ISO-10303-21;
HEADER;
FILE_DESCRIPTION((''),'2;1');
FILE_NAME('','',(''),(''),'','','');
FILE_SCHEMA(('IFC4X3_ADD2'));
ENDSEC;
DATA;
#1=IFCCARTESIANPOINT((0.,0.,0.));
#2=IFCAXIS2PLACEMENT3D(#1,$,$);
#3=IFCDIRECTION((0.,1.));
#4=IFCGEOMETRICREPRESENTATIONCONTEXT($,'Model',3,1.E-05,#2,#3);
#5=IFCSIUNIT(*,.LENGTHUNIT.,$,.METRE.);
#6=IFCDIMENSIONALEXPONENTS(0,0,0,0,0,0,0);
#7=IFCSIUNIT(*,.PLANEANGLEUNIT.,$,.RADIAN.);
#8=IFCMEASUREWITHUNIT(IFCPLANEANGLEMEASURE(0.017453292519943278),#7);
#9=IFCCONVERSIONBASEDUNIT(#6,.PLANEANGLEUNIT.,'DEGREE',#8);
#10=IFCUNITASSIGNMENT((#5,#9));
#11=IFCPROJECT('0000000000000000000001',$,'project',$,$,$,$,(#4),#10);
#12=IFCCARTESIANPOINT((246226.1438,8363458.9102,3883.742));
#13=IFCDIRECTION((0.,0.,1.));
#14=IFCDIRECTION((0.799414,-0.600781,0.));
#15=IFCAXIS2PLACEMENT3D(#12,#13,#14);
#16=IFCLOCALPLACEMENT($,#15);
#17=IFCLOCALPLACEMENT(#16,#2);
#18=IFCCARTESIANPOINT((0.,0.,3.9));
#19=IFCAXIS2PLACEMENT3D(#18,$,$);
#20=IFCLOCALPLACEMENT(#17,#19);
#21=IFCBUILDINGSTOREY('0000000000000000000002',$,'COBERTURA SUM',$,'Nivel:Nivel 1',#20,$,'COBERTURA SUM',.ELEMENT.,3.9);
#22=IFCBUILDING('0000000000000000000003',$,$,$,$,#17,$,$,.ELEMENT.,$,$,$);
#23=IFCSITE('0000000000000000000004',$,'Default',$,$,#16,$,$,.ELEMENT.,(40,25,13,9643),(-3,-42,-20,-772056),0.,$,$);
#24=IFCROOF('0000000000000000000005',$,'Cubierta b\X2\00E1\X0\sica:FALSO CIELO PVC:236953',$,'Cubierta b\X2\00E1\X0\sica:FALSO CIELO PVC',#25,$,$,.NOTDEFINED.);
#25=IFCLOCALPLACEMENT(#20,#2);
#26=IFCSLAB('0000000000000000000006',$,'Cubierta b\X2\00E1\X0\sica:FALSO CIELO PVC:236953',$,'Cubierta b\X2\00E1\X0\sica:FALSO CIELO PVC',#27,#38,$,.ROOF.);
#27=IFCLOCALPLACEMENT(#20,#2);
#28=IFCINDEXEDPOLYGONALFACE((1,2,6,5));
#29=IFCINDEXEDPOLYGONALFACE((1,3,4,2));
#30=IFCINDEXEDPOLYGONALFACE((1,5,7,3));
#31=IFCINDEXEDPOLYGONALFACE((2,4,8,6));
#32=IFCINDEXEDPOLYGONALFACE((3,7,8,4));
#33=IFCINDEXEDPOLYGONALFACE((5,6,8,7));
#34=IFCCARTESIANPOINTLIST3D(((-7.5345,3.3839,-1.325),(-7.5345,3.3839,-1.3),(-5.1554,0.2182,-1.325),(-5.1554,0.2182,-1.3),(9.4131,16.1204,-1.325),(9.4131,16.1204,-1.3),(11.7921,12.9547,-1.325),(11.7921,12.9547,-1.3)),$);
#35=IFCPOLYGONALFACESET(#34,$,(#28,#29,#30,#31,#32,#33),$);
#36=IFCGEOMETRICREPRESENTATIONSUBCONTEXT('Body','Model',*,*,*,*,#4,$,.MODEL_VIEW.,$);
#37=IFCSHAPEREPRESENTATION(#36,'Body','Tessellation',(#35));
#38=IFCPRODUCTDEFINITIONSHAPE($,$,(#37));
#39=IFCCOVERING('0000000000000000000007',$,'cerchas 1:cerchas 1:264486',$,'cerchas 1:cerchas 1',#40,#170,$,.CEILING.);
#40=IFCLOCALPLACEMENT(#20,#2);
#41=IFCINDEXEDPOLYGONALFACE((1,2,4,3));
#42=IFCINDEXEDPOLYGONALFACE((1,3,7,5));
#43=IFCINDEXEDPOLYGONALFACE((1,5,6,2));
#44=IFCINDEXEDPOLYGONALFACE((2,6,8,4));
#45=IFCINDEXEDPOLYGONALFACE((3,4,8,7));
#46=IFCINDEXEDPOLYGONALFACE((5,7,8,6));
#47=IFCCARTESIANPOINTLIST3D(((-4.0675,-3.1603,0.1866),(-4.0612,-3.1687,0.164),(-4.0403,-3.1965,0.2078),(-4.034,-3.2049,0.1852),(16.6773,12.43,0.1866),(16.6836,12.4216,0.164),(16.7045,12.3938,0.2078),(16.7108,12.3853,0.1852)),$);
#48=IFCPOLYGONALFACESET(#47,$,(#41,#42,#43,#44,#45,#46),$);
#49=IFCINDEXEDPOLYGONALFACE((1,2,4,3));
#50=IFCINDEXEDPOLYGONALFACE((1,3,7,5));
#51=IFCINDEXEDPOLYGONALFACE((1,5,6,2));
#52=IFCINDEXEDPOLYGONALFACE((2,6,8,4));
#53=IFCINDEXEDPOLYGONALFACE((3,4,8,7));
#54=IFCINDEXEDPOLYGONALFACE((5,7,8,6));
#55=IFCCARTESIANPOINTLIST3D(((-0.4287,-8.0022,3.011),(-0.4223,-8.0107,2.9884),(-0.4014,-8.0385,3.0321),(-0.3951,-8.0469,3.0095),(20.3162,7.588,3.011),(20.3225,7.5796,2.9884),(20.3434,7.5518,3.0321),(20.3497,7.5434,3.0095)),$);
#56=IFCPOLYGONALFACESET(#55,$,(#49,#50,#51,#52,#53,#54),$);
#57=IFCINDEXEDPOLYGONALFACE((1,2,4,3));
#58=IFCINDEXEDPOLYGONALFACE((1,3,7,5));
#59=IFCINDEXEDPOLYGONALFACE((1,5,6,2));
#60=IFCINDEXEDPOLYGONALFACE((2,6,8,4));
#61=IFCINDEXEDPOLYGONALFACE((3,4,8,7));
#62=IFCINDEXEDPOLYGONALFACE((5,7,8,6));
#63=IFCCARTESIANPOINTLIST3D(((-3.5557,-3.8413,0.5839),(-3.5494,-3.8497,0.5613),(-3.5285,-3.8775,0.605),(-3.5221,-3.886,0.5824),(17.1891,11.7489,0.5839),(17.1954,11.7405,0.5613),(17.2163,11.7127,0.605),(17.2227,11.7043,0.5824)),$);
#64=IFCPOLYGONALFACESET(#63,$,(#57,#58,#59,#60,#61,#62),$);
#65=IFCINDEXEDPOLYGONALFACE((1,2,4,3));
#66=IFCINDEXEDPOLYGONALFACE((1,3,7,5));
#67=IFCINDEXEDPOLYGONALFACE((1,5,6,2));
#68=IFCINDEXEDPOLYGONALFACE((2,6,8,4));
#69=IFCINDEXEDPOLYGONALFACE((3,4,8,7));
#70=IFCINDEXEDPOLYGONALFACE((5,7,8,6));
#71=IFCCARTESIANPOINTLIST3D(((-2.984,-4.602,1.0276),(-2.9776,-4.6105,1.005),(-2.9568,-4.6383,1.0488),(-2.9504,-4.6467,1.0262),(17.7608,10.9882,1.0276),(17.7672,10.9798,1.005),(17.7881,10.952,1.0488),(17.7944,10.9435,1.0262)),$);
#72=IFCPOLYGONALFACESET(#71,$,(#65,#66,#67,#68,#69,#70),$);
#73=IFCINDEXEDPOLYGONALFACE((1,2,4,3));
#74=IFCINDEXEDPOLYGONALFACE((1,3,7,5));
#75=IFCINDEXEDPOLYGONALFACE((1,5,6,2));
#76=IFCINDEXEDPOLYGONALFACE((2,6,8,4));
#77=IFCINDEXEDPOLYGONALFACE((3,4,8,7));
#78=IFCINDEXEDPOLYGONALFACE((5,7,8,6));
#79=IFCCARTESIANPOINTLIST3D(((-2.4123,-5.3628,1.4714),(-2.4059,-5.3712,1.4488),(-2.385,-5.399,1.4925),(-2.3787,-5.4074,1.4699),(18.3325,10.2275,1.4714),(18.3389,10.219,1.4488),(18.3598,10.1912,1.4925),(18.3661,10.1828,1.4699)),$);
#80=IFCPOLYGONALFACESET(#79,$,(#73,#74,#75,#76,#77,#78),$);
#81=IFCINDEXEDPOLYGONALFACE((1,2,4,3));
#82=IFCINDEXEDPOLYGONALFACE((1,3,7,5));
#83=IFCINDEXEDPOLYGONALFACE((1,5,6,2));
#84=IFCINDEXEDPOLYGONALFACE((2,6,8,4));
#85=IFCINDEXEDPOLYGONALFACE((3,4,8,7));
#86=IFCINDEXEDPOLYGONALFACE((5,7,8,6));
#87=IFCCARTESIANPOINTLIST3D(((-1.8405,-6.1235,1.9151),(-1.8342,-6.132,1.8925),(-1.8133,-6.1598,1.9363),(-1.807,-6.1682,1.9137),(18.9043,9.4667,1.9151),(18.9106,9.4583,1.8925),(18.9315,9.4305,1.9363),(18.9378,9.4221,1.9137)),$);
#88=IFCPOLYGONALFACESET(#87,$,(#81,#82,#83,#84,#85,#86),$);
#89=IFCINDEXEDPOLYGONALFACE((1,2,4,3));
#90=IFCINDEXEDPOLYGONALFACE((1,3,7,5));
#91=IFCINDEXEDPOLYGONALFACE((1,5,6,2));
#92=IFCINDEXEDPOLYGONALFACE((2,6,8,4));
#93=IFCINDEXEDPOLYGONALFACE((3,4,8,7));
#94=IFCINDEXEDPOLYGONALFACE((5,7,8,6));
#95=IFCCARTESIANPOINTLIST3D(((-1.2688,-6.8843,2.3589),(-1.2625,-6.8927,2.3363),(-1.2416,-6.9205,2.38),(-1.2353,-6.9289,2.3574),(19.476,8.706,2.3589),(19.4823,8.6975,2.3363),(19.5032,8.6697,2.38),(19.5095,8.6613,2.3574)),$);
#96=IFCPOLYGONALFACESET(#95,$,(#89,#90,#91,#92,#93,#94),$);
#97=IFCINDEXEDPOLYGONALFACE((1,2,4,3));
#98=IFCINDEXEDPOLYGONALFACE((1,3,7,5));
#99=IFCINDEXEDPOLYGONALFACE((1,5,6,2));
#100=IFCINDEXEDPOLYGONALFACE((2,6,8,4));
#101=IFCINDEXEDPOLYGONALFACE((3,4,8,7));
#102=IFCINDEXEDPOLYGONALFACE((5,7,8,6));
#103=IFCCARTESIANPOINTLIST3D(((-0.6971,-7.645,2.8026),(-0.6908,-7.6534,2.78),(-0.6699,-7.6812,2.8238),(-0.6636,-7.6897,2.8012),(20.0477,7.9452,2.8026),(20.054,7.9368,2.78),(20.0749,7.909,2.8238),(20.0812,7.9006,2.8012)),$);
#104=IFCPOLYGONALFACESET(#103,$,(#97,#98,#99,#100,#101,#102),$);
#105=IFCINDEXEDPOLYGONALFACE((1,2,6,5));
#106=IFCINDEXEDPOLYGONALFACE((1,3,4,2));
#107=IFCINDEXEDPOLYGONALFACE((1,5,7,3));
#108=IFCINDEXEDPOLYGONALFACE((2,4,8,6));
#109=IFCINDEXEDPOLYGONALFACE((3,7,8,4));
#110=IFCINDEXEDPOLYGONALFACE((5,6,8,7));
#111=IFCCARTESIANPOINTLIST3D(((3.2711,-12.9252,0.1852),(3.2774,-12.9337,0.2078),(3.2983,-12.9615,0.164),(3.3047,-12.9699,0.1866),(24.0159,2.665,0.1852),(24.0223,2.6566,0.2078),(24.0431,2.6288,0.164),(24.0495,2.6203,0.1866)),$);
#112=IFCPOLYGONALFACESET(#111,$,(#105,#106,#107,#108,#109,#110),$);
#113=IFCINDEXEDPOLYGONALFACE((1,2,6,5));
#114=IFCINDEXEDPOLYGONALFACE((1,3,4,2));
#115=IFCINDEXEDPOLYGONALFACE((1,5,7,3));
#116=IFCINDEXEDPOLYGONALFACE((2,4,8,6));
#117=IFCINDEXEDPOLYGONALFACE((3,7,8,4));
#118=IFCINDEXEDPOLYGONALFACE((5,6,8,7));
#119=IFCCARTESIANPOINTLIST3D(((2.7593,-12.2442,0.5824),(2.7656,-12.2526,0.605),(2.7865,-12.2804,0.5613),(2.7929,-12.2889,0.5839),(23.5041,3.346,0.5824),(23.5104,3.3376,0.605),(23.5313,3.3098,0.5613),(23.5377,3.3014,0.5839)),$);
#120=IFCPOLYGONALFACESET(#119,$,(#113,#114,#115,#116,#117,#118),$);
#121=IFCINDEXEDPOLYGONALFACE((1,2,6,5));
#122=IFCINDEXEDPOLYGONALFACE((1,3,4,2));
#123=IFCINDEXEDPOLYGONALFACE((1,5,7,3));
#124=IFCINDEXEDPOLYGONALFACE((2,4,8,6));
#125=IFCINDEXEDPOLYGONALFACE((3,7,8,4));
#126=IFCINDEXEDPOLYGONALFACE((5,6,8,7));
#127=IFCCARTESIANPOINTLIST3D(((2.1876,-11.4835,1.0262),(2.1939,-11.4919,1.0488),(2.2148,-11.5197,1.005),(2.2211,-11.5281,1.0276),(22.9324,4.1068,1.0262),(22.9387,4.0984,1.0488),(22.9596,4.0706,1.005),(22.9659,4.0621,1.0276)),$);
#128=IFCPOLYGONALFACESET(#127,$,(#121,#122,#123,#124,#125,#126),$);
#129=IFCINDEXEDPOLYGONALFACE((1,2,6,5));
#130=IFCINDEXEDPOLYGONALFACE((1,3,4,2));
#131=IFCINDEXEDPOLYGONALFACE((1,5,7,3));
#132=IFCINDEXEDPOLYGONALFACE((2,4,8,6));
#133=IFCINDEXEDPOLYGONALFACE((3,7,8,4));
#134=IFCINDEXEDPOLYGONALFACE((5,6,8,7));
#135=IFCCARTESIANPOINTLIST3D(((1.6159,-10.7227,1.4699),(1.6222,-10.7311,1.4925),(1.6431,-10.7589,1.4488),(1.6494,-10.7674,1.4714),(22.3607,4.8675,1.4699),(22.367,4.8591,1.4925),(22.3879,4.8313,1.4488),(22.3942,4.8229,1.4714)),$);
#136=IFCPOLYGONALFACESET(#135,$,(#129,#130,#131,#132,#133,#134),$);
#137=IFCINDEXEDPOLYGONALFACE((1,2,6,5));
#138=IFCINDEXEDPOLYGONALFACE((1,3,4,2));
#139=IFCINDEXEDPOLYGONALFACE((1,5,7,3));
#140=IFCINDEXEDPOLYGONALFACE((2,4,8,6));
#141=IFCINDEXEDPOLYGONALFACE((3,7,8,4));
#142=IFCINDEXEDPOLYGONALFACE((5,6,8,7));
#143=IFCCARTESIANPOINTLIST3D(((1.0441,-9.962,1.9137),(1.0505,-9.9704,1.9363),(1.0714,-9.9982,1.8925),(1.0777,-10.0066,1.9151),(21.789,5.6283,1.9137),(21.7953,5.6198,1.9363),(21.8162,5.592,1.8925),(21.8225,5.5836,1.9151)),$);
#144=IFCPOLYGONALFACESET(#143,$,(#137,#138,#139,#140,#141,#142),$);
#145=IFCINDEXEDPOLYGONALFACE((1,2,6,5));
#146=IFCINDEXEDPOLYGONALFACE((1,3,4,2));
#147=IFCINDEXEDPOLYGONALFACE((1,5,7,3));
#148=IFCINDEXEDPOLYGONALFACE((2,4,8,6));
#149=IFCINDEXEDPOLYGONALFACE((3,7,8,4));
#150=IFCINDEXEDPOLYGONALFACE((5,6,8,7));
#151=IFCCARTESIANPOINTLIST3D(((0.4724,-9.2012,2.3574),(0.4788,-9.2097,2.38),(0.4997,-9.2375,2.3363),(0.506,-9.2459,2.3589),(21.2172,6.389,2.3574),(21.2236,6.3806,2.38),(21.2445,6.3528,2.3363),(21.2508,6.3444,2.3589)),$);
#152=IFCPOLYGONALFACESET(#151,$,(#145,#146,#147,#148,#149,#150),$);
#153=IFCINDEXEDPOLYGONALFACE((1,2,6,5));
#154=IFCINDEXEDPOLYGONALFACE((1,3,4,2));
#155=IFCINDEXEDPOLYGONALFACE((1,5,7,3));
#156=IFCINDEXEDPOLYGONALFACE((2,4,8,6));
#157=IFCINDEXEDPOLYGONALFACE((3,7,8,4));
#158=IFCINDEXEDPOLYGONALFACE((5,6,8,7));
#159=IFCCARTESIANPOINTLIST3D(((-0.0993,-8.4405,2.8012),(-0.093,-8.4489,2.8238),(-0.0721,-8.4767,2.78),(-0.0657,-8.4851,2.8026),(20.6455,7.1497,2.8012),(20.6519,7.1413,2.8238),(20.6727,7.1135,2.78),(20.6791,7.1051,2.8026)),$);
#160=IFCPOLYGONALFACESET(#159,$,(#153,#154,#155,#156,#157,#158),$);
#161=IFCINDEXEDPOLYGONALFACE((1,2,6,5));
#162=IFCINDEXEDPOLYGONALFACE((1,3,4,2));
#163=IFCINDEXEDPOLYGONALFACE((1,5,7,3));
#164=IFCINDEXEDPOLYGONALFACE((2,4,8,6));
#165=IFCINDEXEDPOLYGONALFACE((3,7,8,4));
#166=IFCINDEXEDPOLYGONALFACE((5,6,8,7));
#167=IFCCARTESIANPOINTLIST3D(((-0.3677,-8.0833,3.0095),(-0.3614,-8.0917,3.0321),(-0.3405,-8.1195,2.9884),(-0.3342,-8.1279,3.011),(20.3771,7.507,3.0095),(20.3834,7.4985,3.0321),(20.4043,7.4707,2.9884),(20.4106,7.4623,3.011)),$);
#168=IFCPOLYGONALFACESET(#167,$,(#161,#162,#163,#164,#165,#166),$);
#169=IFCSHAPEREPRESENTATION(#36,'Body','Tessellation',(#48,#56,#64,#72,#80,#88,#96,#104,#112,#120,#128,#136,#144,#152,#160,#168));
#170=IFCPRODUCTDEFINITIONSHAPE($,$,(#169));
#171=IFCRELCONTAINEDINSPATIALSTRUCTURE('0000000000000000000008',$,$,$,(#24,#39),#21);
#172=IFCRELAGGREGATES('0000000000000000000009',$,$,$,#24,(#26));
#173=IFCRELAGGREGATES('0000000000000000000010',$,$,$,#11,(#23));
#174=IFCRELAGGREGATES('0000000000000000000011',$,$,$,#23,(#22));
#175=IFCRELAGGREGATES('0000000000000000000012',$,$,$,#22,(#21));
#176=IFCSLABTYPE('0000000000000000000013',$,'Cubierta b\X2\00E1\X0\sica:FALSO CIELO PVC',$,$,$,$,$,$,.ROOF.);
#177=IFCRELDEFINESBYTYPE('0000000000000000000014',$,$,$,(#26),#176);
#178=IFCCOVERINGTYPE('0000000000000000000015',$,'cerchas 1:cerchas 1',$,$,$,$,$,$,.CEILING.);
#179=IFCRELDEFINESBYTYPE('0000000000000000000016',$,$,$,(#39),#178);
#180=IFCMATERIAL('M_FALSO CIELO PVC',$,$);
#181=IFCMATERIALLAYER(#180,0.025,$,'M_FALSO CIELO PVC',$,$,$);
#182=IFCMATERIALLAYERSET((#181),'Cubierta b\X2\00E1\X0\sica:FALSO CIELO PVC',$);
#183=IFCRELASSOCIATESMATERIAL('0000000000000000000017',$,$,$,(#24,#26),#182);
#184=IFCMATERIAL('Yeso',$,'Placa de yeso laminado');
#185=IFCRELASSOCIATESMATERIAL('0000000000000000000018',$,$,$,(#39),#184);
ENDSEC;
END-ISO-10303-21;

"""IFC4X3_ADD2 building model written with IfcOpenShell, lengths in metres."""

from ifc_helpers import new_model, entity, si_unit, converted_unit, direction, frame, frame_2d, origin, origin_2d_with_axis, place, context, subcontext, project, spatial, rectangle, extrude, material, layer, layer_set, type_object, element, aggregate, save


model = new_model("IFC4X3_ADD2")

# Units and contexts
model_context = context("Model", 3, precision=1e-05, world=origin(), true_north=direction((0.0, 1.0)))
body_context = subcontext(model_context, "Body", "Model", "MODEL_VIEW")
ifc_project = project(units=[si_unit("LENGTHUNIT", "METRE"), converted_unit("PLANEANGLEUNIT", "DEGREE", entity("IfcPlaneAngleMeasure", 0.017453292519943278), si_unit("PLANEANGLEUNIT", "RADIAN"), dimensions=[0, 0, 0, 0, 0, 0, 0])], contexts=[model_context])

# Site, building, storey
site_placement = place(None, frame((246226.1438, 8363458.9102, 3883.742), z_axis=(0.0, 0.0, 1.0), x_axis=(0.799414, -0.600781, 0.0)))
site = spatial("IfcSite", under=ifc_project, at=site_placement, Name="Default", CompositionType="ELEMENT", RefLatitude=(40, 25, 13, 9643), RefLongitude=(-3, -42, -20, -772056), RefElevation=0.0)
building_placement = place(site_placement, origin())
building = spatial("IfcBuilding", under=site, at=building_placement, CompositionType="ELEMENT")
storey_placement = place(building_placement, frame((0.0, 0.0, 3.9)))
storey = spatial("IfcBuildingStorey", under=building, at=storey_placement, Name="COBERTURA SUM", ObjectType="Nivel:Nivel 1", LongName="COBERTURA SUM", CompositionType="ELEMENT", Elevation=3.9)

# Shared definitions
ifc_material_1 = material(Name="M_FALSO CIELO PVC")
ifc_layer_1 = layer(ifc_material_1, 0.025, Name="M_FALSO CIELO PVC")
ifc_layer_set_1 = layer_set([ifc_layer_1], Name="Cubierta básica:FALSO CIELO PVC")
slab_type_1 = type_object("IfcSlabType", Name="Cubierta básica:FALSO CIELO PVC", PredefinedType="ROOF")

# Roof, slab
roof_1_placement = place(storey_placement, frame((-7.5345, 0.2182, -1.325)))
roof_1 = element("IfcRoof", 1, at=roof_1_placement, inside=storey, material=ifc_layer_set_1, Name="Cubierta básica:FALSO CIELO PVC:236953", ObjectType="Cubierta básica:FALSO CIELO PVC", PredefinedType="NOTDEFINED")
slab_1_placement = place(roof_1_placement, origin())
slab_1 = element("IfcSlab", 2, at=slab_1_placement, type_object=slab_type_1, material=ifc_layer_set_1, Name="Cubierta básica:FALSO CIELO PVC:236953", ObjectType="Cubierta básica:FALSO CIELO PVC", PredefinedType="ROOF", context=body_context, shape_type="SweptSolid", body=[
    extrude(rectangle(XDim=3.96, YDim=21.2, at=frame_2d((0.0, 0.0), x_axis=(0.60078, -0.799414))), frame((9.6633, 7.9511, 0.0)), (0.0, 0.0, 1.0), 0.025),
])
aggregate(roof_1, [slab_1])

# Covering
ifc_material_2 = material(Name="Yeso", Category="Placa de yeso laminado")
covering_type = type_object("IfcCoveringType", Name="cerchas 1:cerchas 1", PredefinedType="CEILING")
covering_placement = place(storey_placement, frame((-4.0675, -12.9699, 0.164)))
element("IfcCovering", 3, at=covering_placement, inside=storey, type_object=covering_type, material=ifc_material_2, Name="cerchas 1:cerchas 1:264486", ObjectType="cerchas 1:cerchas 1", PredefinedType="CEILING", context=body_context, shape_type="SweptSolid", body=[
    extrude(rectangle(XDim=0.0249, YDim=0.05, at=frame_2d((0.0, 0.0), x_axis=(0.0, 1.0))), frame((0.0168, 9.7873, 0.0219), z_axis=(0.799414, 0.60078, 0.0), x_axis=(0.544492, -0.724516, 0.422618)), (0.0, 0.0, 1.0), 25.95),
    extrude(rectangle(XDim=0.0249, YDim=0.05, at=frame_2d((0.0, 0.0), x_axis=(0.0, 1.0))), frame((3.6556, 4.9453, 2.8462), z_axis=(0.799414, 0.60078, 0.0), x_axis=(0.544492, -0.724516, 0.422618)), (0.0, 0.0, 1.0), 25.95),
    extrude(rectangle(XDim=0.0249, YDim=0.05, at=frame_2d((0.0, 0.0), x_axis=(0.0, 1.0))), frame((0.5286, 9.1063, 0.4191), z_axis=(0.799414, 0.60078, 0.0), x_axis=(0.544492, -0.724516, 0.422618)), (0.0, 0.0, 1.0), 25.95),
    extrude(rectangle(XDim=0.0249, YDim=0.05, at=frame_2d((0.0, 0.0), x_axis=(0.0, 1.0))), frame((1.1003, 8.3455, 0.8629), z_axis=(0.799414, 0.60078, 0.0), x_axis=(0.544492, -0.724516, 0.422618)), (0.0, 0.0, 1.0), 25.95),
    extrude(rectangle(XDim=0.0249, YDim=0.05, at=frame_2d((0.0, 0.0), x_axis=(0.0, 1.0))), frame((1.672, 7.5848, 1.3066), z_axis=(0.799414, 0.60078, 0.0), x_axis=(0.544492, -0.724516, 0.422618)), (0.0, 0.0, 1.0), 25.95),
    extrude(rectangle(XDim=0.0249, YDim=0.05, at=frame_2d((0.0, 0.0), x_axis=(0.0, 1.0))), frame((2.2437, 6.824, 1.7504), z_axis=(0.799414, 0.60078, 0.0), x_axis=(0.544492, -0.724516, 0.422618)), (0.0, 0.0, 1.0), 25.95),
    extrude(rectangle(XDim=0.0249, YDim=0.05, at=frame_2d((0.0, 0.0), x_axis=(0.0, 1.0))), frame((2.8155, 6.0633, 2.1941), z_axis=(0.799414, 0.60078, 0.0), x_axis=(0.544492, -0.724516, 0.422618)), (0.0, 0.0, 1.0), 25.95),
    extrude(rectangle(XDim=0.0249, YDim=0.05, at=frame_2d((0.0, 0.0), x_axis=(0.0, 1.0))), frame((3.3872, 5.3026, 2.6379), z_axis=(0.799414, 0.60078, 0.0), x_axis=(0.544492, -0.724516, 0.422618)), (0.0, 0.0, 1.0), 25.95),
    extrude(rectangle(XDim=0.0249, YDim=0.05, at=origin_2d_with_axis()), frame((7.3554, 0.0223, 0.0219), z_axis=(0.799414, 0.60078, 0.0), x_axis=(-0.253901, 0.337847, -0.906308)), (0.0, 0.0, 1.0), 25.95),
    extrude(rectangle(XDim=0.0249, YDim=0.05, at=frame_2d((0.0, 0.0), x_axis=(1.0, 0.0))), frame((6.8436, 0.7034, 0.4191), z_axis=(0.799414, 0.60078, 0.0), x_axis=(-0.253901, 0.337847, -0.906308)), (0.0, 0.0, 1.0), 25.95),
    extrude(rectangle(XDim=0.0249, YDim=0.05, at=frame_2d((0.0, 0.0), x_axis=(1.0, 0.0))), frame((6.2719, 1.4641, 0.8629), z_axis=(0.799414, 0.60078, 0.0), x_axis=(-0.253901, 0.337847, -0.906308)), (0.0, 0.0, 1.0), 25.95),
    extrude(rectangle(XDim=0.0249, YDim=0.05, at=frame_2d((0.0, 0.0), x_axis=(1.0, 0.0))), frame((5.7002, 2.2249, 1.3066), z_axis=(0.799414, 0.60078, 0.0), x_axis=(-0.253901, 0.337847, -0.906308)), (0.0, 0.0, 1.0), 25.95),
    extrude(rectangle(XDim=0.0249, YDim=0.05, at=frame_2d((0.0, 0.0), x_axis=(1.0, 0.0))), frame((5.1284, 2.9856, 1.7504), z_axis=(0.799414, 0.60078, 0.0), x_axis=(-0.253901, 0.337847, -0.906308)), (0.0, 0.0, 1.0), 25.95),
    extrude(rectangle(XDim=0.0249, YDim=0.05, at=frame_2d((0.0, 0.0), x_axis=(1.0, 0.0))), frame((4.5567, 3.7463, 2.1941), z_axis=(0.799414, 0.60078, 0.0), x_axis=(-0.253901, 0.337847, -0.906308)), (0.0, 0.0, 1.0), 25.95),
    extrude(rectangle(XDim=0.0249, YDim=0.05, at=frame_2d((0.0, 0.0), x_axis=(1.0, 0.0))), frame((3.985, 4.5071, 2.6379), z_axis=(0.799414, 0.60078, 0.0), x_axis=(-0.253901, 0.337847, -0.906308)), (0.0, 0.0, 1.0), 25.95),
    extrude(rectangle(XDim=0.0249, YDim=0.05, at=frame_2d((0.0, 0.0), x_axis=(1.0, 0.0))), frame((3.7165, 4.8643, 2.8462), z_axis=(0.799414, 0.60078, 0.0), x_axis=(-0.253901, 0.337847, -0.906308)), (0.0, 0.0, 1.0), 25.95),
])

save(model, "model.ifc")
